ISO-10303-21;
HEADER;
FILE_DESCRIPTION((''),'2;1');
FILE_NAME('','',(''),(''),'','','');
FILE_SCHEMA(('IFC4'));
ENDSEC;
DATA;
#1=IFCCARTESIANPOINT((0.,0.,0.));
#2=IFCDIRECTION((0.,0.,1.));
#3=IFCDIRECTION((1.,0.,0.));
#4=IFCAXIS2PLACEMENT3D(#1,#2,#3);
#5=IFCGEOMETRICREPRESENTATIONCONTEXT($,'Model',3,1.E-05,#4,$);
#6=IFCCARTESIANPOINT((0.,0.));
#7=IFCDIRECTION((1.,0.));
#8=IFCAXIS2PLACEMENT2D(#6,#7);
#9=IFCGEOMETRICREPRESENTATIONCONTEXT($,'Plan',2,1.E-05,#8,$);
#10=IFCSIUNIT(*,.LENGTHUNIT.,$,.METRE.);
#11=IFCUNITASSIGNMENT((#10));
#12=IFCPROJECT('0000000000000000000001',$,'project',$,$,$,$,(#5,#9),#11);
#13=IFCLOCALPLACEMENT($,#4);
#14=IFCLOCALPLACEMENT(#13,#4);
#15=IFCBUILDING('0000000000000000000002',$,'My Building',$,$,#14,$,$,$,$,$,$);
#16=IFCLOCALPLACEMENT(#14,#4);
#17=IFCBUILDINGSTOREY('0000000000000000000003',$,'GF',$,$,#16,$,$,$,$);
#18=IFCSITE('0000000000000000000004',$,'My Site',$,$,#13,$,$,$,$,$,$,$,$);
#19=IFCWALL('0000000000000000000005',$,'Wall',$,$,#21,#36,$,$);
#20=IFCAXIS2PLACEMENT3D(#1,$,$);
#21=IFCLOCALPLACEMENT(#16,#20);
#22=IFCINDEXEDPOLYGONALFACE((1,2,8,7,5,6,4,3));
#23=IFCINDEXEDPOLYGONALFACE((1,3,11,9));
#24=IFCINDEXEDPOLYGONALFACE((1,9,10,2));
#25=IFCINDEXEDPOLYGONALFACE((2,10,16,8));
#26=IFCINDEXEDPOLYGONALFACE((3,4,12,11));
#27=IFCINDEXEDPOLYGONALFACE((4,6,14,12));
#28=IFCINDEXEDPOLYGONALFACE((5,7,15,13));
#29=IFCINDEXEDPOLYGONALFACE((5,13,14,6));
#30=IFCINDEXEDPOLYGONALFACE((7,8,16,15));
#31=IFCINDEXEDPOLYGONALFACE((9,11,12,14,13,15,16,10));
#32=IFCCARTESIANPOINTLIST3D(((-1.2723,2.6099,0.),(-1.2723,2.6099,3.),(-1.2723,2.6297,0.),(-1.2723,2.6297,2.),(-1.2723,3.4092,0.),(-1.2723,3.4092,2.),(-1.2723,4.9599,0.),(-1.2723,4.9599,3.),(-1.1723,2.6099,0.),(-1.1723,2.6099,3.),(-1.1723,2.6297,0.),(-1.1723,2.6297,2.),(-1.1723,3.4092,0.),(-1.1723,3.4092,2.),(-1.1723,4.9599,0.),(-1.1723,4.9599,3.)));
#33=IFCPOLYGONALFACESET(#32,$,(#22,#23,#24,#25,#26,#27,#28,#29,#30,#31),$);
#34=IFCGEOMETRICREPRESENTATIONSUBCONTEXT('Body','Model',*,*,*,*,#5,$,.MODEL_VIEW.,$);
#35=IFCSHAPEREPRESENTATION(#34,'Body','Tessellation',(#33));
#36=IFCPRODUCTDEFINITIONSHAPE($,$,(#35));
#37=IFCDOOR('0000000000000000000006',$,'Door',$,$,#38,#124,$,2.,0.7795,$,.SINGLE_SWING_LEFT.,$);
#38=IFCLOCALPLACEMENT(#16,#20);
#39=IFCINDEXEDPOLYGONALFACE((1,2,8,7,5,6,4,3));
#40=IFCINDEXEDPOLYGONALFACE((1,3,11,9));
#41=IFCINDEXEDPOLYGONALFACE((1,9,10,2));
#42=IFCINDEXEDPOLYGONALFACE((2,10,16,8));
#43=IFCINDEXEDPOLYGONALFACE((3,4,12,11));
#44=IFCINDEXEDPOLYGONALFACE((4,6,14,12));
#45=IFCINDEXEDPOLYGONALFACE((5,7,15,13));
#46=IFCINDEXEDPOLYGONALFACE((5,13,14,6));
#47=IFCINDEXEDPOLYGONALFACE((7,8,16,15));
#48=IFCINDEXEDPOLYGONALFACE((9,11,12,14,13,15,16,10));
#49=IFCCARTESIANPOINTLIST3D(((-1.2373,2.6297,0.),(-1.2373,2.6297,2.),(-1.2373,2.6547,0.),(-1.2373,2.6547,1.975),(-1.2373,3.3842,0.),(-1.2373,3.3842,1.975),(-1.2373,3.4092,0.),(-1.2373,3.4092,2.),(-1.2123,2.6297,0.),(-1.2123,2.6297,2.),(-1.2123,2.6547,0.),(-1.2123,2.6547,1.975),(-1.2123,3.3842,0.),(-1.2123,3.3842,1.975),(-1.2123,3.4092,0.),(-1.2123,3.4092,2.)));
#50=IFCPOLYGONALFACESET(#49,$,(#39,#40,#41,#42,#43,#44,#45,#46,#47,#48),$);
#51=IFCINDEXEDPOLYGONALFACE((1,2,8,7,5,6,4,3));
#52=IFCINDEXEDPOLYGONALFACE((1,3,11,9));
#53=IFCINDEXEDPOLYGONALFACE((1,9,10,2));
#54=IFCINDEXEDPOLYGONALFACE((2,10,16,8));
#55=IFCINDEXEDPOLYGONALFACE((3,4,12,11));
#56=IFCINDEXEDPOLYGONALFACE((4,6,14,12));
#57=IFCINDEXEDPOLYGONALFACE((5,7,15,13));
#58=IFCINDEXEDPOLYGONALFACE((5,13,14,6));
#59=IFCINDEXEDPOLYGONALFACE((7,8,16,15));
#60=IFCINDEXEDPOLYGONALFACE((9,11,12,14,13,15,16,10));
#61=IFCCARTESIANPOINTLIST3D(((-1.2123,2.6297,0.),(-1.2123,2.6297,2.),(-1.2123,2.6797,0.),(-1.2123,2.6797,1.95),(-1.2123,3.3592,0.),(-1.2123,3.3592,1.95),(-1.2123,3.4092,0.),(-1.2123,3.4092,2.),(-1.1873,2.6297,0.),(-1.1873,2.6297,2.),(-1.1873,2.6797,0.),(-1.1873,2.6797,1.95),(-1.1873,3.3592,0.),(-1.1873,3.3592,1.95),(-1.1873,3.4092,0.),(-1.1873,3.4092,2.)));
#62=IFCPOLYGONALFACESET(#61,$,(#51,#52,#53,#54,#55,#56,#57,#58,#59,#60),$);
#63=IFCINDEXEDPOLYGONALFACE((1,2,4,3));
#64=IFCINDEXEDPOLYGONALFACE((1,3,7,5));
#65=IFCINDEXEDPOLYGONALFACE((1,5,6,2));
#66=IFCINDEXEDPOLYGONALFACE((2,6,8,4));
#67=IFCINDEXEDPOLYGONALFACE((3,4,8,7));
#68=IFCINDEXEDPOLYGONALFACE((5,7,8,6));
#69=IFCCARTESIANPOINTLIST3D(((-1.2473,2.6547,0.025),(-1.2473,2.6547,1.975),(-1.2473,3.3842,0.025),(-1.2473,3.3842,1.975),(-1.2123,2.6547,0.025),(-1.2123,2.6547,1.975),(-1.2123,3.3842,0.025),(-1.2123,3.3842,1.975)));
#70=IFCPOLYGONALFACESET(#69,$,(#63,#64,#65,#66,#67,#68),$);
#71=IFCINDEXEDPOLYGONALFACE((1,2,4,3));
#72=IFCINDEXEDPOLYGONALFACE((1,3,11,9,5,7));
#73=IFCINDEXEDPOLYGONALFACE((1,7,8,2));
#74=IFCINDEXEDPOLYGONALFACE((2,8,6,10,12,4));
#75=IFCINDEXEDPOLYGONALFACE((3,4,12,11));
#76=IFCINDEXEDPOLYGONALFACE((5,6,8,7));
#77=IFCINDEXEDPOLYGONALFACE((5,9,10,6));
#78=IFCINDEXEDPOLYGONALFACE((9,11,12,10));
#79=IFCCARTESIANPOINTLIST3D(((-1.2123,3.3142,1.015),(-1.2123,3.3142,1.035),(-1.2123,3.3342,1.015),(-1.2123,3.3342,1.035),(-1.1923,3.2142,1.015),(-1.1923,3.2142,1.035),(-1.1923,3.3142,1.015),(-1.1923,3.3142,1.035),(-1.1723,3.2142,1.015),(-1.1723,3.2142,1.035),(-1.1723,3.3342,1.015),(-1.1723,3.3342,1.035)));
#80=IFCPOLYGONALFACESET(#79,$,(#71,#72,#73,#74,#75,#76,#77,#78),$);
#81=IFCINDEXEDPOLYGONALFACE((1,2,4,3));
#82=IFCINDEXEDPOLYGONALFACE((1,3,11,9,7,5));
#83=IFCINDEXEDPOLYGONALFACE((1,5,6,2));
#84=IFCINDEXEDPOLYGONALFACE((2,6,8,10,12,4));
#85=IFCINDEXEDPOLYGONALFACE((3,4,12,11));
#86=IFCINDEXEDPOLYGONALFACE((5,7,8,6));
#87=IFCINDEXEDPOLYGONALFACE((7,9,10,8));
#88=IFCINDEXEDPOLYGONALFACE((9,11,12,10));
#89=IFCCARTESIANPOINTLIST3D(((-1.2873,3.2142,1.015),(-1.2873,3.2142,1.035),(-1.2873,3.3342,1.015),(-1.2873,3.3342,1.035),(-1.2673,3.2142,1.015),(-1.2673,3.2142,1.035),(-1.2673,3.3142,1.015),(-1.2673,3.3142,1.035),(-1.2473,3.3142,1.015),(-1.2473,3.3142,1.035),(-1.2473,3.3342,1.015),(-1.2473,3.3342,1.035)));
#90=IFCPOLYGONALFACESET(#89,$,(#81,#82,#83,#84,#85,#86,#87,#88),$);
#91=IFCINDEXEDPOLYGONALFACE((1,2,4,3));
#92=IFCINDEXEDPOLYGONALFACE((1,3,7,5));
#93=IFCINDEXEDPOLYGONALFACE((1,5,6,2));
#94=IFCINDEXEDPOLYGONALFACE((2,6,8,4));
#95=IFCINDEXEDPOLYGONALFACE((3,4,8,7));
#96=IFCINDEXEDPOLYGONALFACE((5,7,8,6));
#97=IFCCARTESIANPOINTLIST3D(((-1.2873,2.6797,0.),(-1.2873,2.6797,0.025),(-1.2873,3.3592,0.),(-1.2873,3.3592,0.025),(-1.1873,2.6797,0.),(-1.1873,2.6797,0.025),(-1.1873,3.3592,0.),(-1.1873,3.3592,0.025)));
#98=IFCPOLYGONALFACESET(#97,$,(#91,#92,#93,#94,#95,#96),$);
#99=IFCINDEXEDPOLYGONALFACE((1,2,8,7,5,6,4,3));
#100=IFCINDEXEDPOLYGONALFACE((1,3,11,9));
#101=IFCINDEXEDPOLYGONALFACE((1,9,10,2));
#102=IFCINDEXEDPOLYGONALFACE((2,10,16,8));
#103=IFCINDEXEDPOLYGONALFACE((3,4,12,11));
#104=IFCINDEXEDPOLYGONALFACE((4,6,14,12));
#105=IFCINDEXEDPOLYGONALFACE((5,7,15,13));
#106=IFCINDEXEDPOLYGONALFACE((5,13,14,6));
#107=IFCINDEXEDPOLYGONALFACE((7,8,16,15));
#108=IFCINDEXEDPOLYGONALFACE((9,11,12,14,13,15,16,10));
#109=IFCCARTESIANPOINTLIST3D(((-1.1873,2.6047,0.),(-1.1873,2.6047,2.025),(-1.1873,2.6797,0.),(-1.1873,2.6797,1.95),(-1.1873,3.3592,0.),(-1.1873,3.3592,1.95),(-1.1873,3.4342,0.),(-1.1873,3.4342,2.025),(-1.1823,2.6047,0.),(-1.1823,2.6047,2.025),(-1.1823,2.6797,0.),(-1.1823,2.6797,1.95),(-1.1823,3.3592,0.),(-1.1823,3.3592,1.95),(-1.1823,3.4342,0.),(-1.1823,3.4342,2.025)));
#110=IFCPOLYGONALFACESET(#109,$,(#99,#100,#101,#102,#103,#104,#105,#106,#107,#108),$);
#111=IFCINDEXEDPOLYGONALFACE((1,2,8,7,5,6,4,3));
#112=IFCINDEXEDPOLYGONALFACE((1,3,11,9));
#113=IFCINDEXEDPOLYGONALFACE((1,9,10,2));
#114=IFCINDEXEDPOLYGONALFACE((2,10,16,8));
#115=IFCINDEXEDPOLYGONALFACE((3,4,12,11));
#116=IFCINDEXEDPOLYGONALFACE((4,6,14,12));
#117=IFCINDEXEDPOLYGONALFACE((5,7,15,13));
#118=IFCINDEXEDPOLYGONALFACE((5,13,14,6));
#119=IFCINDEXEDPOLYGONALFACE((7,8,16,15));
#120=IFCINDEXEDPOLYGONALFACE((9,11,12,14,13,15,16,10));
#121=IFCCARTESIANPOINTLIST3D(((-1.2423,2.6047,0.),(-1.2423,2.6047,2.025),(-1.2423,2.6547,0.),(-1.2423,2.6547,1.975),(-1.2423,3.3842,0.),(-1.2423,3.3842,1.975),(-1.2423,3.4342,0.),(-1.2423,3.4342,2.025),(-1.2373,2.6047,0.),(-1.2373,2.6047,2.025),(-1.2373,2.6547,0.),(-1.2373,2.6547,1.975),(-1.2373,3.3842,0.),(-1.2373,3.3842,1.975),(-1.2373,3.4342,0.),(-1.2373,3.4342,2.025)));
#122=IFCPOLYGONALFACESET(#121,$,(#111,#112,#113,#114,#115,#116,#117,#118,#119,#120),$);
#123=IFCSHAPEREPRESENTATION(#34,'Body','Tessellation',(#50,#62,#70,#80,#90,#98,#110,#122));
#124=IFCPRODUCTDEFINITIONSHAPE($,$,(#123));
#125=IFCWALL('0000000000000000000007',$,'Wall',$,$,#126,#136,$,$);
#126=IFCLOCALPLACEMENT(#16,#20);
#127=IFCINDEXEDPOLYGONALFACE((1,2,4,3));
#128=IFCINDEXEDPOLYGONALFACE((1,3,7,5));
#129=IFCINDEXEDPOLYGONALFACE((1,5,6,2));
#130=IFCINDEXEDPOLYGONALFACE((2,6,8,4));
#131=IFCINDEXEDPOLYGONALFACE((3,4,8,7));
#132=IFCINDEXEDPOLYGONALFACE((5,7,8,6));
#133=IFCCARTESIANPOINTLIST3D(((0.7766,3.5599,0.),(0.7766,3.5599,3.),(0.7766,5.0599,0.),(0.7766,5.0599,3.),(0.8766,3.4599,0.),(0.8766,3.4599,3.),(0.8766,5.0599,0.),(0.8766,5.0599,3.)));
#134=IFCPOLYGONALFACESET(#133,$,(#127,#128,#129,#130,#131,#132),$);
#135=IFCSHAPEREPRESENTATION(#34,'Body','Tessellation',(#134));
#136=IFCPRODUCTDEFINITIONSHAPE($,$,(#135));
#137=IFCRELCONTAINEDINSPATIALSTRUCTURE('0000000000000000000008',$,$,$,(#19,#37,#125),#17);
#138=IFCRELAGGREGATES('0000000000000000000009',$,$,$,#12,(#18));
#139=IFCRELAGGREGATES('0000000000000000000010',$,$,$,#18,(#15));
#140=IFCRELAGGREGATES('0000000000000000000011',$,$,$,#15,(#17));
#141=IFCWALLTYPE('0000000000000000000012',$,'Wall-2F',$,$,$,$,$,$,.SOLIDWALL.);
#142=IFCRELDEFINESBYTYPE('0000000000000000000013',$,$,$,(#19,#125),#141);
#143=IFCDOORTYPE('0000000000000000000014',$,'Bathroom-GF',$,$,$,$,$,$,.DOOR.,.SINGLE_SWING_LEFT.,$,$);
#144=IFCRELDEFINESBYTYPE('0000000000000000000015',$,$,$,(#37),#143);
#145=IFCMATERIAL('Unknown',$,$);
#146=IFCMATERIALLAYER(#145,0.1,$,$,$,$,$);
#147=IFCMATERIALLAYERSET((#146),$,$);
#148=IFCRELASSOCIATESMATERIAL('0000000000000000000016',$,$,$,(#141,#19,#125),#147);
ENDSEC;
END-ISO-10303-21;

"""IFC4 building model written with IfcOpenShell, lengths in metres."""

from ifc_helpers import new_model, entity, si_unit, frame, origin_with_axes, origin_2d_with_axis, place, context, subcontext, project, spatial, line, indexed_curve, outline, extrude, shape, source, transform, mapped, material, layer, layer_set, layer_usage, type_object, type_shapes, element, fill, save


model = new_model("IFC4")

# Units and contexts
model_context = context("Model", 3, precision=1e-05, world=origin_with_axes())
plan_context = context("Plan", 2, precision=1e-05, world=origin_2d_with_axis())
body_context_1 = subcontext(model_context, "Body", "Model", "MODEL_VIEW")
body_context_2 = subcontext(plan_context, "Body", "Plan", "PLAN_VIEW")
ifc_project = project(units=[si_unit("LENGTHUNIT", "METRE")], contexts=[model_context, plan_context])

# Site, building, storey
site_placement = place(None, origin_with_axes())
site = spatial("IfcSite", under=ifc_project, at=site_placement, Name="My Site")
building_placement = place(site_placement, origin_with_axes())
building = spatial("IfcBuilding", under=site, at=building_placement, Name="My Building")
storey_placement = place(building_placement, origin_with_axes())
storey = spatial("IfcBuildingStorey", under=building, at=storey_placement, Name="GF")

# Shared definitions
ifc_material = material(Name="Unknown")

# Shared definitions
ifc_layer_1 = layer(ifc_material, 0.1)
ifc_layer_set_1 = layer_set([ifc_layer_1])
wall_type = type_object("IfcWallType", Name="Wall-2F", PredefinedType="SOLIDWALL", material=ifc_layer_set_1)

# Wall, opening, door
ifc_layer_usage_1 = layer_usage(ifc_layer_set_1, "AXIS2", "POSITIVE", 0.0)
wall_1_placement = place(storey_placement, frame((-1.1723, 2.6099, 0.0), z_axis=(0.0, 0.0, 1.0), x_axis=(0.0, 1.0, 0.0)))
wall_1 = element("IfcWall", 1, at=wall_1_placement, inside=storey, type_object=wall_type, material=ifc_layer_usage_1, Name="Wall", context=body_context_1, shape_type="SweptSolid", body=[
    extrude(outline(indexed_curve([(0.0, 0.0), (0.0, 0.1), (2.35, 0.1), (2.35, 0.0)], segments=[line(1, 2, 3, 4, 1)])), origin_with_axes(), (0.0, 0.0, 1.0), 3.0),
])
shared_shape_1 = source(origin_with_axes(), body_context_1, "Body", "SweptSolid", [
    extrude(outline(indexed_curve([(0.0, 0.0), (0.7795, 0.0), (0.7795, 2.0), (0.0, 2.0)], segments=[line(1, 2, 3, 4, 1)])), frame((0.0, -0.6, 0.0), z_axis=(0.0, -1.0, 0.0), x_axis=(1.0, 0.0, 0.0)), (0.0, 0.0, -1.0), 1.2),
])
opening_1_placement = place(wall_1_placement, frame((0.0198, 0.015, 0.0), z_axis=(0.0, 0.0, 1.0), x_axis=(1.0, 0.0, 0.0)))
opening_1 = element("IfcOpeningElement", 2, at=opening_1_placement, cuts=wall_1, PredefinedType="OPENING", context=body_context_1, shape_type="MappedRepresentation", body=[
    mapped(shared_shape_1, transform((0.0, 0.0, 0.0), x_axis=(1.0, 0.0, 0.0), y_axis=(0.0, 1.0, 0.0), z_axis=(0.0, 0.0, 1.0), scale=1.0)),
])
door_type_1 = type_object("IfcDoorType", Name="Bathroom-GF", OperationType="SINGLE_SWING_LEFT", PredefinedType="DOOR")
shared_shape_2 = source(origin_with_axes(), body_context_1, "Body", "SweptSolid", [
    extrude(outline(indexed_curve([(0.0, 0.0), (0.0, 2.0), (0.7795, 2.0), (0.7795, 0.0), (0.7545, 0.0), (0.7545, 1.975), (0.025, 1.975), (0.025, 0.0)], segments=[line(1, 2, 3, 4, 5, 6, 7, 8, 1)])), frame((0.0, 0.025, 0.0), z_axis=(0.0, -1.0, 0.0), x_axis=(1.0, 0.0, 0.0)), (0.0, 0.0, -1.0), 0.025),
    extrude(outline(indexed_curve([(0.0, 0.0), (0.0, 2.0), (0.7795, 2.0), (0.7795, 0.0), (0.7295, 0.0), (0.7295, 1.95), (0.05, 1.95), (0.05, 0.0)], segments=[line(1, 2, 3, 4, 5, 6, 7, 8, 1)])), frame((0.0, 0.0, 0.0), z_axis=(0.0, -1.0, 0.0), x_axis=(1.0, 0.0, 0.0)), (0.0, 0.0, -1.0), 0.025),
    extrude(outline(indexed_curve([(0.0, 0.0), (0.7295, 0.0), (0.7295, 0.035), (0.0, 0.035)], segments=[line(1, 2, 3, 4, 1)])), frame((0.025, 0.025, 0.025), z_axis=(0.0, 0.0, 1.0), x_axis=(1.0, 0.0, 0.0)), (0.0, 0.0, 1.0), 1.95),
    extrude(outline(indexed_curve([(0.0, 0.0), (0.0, -0.04), (-0.12, -0.04), (-0.12, -0.02), (-0.02, -0.02), (-0.02, 0.0)], segments=[line(1, 2, 3, 4, 5, 6, 1)])), frame((0.7045, 0.025, 1.015), z_axis=(0.0, 0.0, 1.0), x_axis=(1.0, 0.0, 0.0)), (0.0, 0.0, 1.0), 0.02),
    extrude(outline(indexed_curve([(0.0, 0.0), (0.0, 0.04), (-0.12, 0.04), (-0.12, 0.02), (-0.02, 0.02), (-0.02, 0.0)], segments=[line(1, 2, 3, 4, 5, 6, 1)])), frame((0.7045, 0.06, 1.015), z_axis=(0.0, 0.0, 1.0), x_axis=(1.0, 0.0, 0.0)), (0.0, 0.0, 1.0), 0.02),
    extrude(outline(indexed_curve([(0.0, 0.0), (0.6795, 0.0), (0.6795, 0.1), (0.0, 0.1)], segments=[line(1, 2, 3, 4, 1)])), frame((0.05, 0.0, 0.0), z_axis=(0.0, 0.0, 1.0), x_axis=(1.0, 0.0, 0.0)), (0.0, 0.0, 1.0), 0.025),
    extrude(outline(indexed_curve([(0.0, 0.0), (0.0, 2.025), (0.8295, 2.025), (0.8295, 0.0), (0.7545, 0.0), (0.7545, 1.95), (0.075, 1.95), (0.075, 0.0)], segments=[line(1, 2, 3, 4, 5, 6, 7, 8, 1)])), frame((-0.025, -0.005, 0.0), z_axis=(0.0, -1.0, 0.0), x_axis=(1.0, 0.0, 0.0)), (0.0, 0.0, -1.0), 0.005),
    extrude(outline(indexed_curve([(0.0, 0.0), (0.0, 2.025), (0.8295, 2.025), (0.8295, 0.0), (0.7795, 0.0), (0.7795, 1.975), (0.05, 1.975), (0.05, 0.0)], segments=[line(1, 2, 3, 4, 5, 6, 7, 8, 1)])), frame((-0.025, 0.05, 0.0), z_axis=(0.0, -1.0, 0.0), x_axis=(1.0, 0.0, 0.0)), (0.0, 0.0, -1.0), 0.005),
])
shared_shape_3 = source(origin_with_axes(), body_context_2, "Body", "Curve2D", [
    entity("IfcIndexedPolyCurve", entity("IfcCartesianPointList2D", [[0.0, 0.0], [0.0, 0.05], [0.025, 0.05], [0.025, 0.025], [0.05, 0.025], [0.05, 0.0]]), [entity("IfcLineIndex", [1, 2, 3, 4, 5, 6, 1])]),
    entity("IfcIndexedPolyCurve", entity("IfcCartesianPointList2D", [[0.7795, 0.0], [0.7795, 0.05], [0.7545, 0.05], [0.7545, 0.025], [0.7295, 0.025], [0.7295, 0.0]]), [entity("IfcLineIndex", [1, 2, 3, 4, 5, 6, 1])]),
    entity("IfcTrimmedCurve", entity("IfcEllipse", entity("IfcAxis2Placement2D", entity("IfcCartesianPoint", [0.06, 0.05]), entity("IfcDirection", [1.0, 0.0])), 0.6945, 0.7295), [entity("IfcCartesianPoint", [0.7545, 0.05])], [entity("IfcCartesianPoint", [0.06, 0.7795])], True, "CARTESIAN"),
    entity("IfcIndexedPolyCurve", entity("IfcCartesianPointList2D", [[0.025, 0.05], [0.06, 0.05], [0.06, 0.7795], [0.025, 0.7795]]), [entity("IfcLineIndex", [1, 2, 3, 4, 1])]),
])
type_shapes(door_type_1, [shared_shape_2, shared_shape_3])
door_1_placement = place(opening_1_placement, frame((0.0, 0.0, 0.0), z_axis=(0.0, 0.0, 1.0), x_axis=(1.0, 0.0, 0.0)))
door_1 = element("IfcDoor", 3, at=door_1_placement, inside=storey, type_object=door_type_1, Name="Door", OperationType="SINGLE_SWING_LEFT", OverallHeight=2.0, OverallWidth=0.7795, shapes=[
    shape(body_context_1, "Body", "MappedRepresentation", [mapped(shared_shape_2, transform((0.0, 0.0, 0.0), x_axis=(1.0, 0.0, 0.0), y_axis=(0.0, 1.0, 0.0), z_axis=(0.0, 0.0, 1.0), scale=1.0))]),
    shape(body_context_2, "Body", "MappedRepresentation", [mapped(shared_shape_3, transform((0.0, 0.0, 0.0), x_axis=(1.0, 0.0, 0.0), y_axis=(0.0, 1.0, 0.0), z_axis=(0.0, 0.0, 1.0), scale=1.0))]),
])
fill(opening_1, door_1)

# Wall
ifc_layer_usage_2 = layer_usage(ifc_layer_set_1, "AXIS2", "POSITIVE", 0.0)
wall_2_placement = place(storey_placement, frame((0.7766, 5.0599, 0.0), z_axis=(0.0, 0.0, 1.0), x_axis=(0.0, -1.0, 0.0)))
element("IfcWall", 4, at=wall_2_placement, inside=storey, type_object=wall_type, material=ifc_layer_usage_2, Name="Wall", context=body_context_1, shape_type="SweptSolid", body=[
    extrude(outline(indexed_curve([(0.0, 0.0), (0.0, 0.1), (1.6, 0.1), (1.5, 0.0)], segments=[line(1, 2, 3, 4, 1)])), origin_with_axes(), (0.0, 0.0, 1.0), 3.0),
])

save(model, "model.ifc")
